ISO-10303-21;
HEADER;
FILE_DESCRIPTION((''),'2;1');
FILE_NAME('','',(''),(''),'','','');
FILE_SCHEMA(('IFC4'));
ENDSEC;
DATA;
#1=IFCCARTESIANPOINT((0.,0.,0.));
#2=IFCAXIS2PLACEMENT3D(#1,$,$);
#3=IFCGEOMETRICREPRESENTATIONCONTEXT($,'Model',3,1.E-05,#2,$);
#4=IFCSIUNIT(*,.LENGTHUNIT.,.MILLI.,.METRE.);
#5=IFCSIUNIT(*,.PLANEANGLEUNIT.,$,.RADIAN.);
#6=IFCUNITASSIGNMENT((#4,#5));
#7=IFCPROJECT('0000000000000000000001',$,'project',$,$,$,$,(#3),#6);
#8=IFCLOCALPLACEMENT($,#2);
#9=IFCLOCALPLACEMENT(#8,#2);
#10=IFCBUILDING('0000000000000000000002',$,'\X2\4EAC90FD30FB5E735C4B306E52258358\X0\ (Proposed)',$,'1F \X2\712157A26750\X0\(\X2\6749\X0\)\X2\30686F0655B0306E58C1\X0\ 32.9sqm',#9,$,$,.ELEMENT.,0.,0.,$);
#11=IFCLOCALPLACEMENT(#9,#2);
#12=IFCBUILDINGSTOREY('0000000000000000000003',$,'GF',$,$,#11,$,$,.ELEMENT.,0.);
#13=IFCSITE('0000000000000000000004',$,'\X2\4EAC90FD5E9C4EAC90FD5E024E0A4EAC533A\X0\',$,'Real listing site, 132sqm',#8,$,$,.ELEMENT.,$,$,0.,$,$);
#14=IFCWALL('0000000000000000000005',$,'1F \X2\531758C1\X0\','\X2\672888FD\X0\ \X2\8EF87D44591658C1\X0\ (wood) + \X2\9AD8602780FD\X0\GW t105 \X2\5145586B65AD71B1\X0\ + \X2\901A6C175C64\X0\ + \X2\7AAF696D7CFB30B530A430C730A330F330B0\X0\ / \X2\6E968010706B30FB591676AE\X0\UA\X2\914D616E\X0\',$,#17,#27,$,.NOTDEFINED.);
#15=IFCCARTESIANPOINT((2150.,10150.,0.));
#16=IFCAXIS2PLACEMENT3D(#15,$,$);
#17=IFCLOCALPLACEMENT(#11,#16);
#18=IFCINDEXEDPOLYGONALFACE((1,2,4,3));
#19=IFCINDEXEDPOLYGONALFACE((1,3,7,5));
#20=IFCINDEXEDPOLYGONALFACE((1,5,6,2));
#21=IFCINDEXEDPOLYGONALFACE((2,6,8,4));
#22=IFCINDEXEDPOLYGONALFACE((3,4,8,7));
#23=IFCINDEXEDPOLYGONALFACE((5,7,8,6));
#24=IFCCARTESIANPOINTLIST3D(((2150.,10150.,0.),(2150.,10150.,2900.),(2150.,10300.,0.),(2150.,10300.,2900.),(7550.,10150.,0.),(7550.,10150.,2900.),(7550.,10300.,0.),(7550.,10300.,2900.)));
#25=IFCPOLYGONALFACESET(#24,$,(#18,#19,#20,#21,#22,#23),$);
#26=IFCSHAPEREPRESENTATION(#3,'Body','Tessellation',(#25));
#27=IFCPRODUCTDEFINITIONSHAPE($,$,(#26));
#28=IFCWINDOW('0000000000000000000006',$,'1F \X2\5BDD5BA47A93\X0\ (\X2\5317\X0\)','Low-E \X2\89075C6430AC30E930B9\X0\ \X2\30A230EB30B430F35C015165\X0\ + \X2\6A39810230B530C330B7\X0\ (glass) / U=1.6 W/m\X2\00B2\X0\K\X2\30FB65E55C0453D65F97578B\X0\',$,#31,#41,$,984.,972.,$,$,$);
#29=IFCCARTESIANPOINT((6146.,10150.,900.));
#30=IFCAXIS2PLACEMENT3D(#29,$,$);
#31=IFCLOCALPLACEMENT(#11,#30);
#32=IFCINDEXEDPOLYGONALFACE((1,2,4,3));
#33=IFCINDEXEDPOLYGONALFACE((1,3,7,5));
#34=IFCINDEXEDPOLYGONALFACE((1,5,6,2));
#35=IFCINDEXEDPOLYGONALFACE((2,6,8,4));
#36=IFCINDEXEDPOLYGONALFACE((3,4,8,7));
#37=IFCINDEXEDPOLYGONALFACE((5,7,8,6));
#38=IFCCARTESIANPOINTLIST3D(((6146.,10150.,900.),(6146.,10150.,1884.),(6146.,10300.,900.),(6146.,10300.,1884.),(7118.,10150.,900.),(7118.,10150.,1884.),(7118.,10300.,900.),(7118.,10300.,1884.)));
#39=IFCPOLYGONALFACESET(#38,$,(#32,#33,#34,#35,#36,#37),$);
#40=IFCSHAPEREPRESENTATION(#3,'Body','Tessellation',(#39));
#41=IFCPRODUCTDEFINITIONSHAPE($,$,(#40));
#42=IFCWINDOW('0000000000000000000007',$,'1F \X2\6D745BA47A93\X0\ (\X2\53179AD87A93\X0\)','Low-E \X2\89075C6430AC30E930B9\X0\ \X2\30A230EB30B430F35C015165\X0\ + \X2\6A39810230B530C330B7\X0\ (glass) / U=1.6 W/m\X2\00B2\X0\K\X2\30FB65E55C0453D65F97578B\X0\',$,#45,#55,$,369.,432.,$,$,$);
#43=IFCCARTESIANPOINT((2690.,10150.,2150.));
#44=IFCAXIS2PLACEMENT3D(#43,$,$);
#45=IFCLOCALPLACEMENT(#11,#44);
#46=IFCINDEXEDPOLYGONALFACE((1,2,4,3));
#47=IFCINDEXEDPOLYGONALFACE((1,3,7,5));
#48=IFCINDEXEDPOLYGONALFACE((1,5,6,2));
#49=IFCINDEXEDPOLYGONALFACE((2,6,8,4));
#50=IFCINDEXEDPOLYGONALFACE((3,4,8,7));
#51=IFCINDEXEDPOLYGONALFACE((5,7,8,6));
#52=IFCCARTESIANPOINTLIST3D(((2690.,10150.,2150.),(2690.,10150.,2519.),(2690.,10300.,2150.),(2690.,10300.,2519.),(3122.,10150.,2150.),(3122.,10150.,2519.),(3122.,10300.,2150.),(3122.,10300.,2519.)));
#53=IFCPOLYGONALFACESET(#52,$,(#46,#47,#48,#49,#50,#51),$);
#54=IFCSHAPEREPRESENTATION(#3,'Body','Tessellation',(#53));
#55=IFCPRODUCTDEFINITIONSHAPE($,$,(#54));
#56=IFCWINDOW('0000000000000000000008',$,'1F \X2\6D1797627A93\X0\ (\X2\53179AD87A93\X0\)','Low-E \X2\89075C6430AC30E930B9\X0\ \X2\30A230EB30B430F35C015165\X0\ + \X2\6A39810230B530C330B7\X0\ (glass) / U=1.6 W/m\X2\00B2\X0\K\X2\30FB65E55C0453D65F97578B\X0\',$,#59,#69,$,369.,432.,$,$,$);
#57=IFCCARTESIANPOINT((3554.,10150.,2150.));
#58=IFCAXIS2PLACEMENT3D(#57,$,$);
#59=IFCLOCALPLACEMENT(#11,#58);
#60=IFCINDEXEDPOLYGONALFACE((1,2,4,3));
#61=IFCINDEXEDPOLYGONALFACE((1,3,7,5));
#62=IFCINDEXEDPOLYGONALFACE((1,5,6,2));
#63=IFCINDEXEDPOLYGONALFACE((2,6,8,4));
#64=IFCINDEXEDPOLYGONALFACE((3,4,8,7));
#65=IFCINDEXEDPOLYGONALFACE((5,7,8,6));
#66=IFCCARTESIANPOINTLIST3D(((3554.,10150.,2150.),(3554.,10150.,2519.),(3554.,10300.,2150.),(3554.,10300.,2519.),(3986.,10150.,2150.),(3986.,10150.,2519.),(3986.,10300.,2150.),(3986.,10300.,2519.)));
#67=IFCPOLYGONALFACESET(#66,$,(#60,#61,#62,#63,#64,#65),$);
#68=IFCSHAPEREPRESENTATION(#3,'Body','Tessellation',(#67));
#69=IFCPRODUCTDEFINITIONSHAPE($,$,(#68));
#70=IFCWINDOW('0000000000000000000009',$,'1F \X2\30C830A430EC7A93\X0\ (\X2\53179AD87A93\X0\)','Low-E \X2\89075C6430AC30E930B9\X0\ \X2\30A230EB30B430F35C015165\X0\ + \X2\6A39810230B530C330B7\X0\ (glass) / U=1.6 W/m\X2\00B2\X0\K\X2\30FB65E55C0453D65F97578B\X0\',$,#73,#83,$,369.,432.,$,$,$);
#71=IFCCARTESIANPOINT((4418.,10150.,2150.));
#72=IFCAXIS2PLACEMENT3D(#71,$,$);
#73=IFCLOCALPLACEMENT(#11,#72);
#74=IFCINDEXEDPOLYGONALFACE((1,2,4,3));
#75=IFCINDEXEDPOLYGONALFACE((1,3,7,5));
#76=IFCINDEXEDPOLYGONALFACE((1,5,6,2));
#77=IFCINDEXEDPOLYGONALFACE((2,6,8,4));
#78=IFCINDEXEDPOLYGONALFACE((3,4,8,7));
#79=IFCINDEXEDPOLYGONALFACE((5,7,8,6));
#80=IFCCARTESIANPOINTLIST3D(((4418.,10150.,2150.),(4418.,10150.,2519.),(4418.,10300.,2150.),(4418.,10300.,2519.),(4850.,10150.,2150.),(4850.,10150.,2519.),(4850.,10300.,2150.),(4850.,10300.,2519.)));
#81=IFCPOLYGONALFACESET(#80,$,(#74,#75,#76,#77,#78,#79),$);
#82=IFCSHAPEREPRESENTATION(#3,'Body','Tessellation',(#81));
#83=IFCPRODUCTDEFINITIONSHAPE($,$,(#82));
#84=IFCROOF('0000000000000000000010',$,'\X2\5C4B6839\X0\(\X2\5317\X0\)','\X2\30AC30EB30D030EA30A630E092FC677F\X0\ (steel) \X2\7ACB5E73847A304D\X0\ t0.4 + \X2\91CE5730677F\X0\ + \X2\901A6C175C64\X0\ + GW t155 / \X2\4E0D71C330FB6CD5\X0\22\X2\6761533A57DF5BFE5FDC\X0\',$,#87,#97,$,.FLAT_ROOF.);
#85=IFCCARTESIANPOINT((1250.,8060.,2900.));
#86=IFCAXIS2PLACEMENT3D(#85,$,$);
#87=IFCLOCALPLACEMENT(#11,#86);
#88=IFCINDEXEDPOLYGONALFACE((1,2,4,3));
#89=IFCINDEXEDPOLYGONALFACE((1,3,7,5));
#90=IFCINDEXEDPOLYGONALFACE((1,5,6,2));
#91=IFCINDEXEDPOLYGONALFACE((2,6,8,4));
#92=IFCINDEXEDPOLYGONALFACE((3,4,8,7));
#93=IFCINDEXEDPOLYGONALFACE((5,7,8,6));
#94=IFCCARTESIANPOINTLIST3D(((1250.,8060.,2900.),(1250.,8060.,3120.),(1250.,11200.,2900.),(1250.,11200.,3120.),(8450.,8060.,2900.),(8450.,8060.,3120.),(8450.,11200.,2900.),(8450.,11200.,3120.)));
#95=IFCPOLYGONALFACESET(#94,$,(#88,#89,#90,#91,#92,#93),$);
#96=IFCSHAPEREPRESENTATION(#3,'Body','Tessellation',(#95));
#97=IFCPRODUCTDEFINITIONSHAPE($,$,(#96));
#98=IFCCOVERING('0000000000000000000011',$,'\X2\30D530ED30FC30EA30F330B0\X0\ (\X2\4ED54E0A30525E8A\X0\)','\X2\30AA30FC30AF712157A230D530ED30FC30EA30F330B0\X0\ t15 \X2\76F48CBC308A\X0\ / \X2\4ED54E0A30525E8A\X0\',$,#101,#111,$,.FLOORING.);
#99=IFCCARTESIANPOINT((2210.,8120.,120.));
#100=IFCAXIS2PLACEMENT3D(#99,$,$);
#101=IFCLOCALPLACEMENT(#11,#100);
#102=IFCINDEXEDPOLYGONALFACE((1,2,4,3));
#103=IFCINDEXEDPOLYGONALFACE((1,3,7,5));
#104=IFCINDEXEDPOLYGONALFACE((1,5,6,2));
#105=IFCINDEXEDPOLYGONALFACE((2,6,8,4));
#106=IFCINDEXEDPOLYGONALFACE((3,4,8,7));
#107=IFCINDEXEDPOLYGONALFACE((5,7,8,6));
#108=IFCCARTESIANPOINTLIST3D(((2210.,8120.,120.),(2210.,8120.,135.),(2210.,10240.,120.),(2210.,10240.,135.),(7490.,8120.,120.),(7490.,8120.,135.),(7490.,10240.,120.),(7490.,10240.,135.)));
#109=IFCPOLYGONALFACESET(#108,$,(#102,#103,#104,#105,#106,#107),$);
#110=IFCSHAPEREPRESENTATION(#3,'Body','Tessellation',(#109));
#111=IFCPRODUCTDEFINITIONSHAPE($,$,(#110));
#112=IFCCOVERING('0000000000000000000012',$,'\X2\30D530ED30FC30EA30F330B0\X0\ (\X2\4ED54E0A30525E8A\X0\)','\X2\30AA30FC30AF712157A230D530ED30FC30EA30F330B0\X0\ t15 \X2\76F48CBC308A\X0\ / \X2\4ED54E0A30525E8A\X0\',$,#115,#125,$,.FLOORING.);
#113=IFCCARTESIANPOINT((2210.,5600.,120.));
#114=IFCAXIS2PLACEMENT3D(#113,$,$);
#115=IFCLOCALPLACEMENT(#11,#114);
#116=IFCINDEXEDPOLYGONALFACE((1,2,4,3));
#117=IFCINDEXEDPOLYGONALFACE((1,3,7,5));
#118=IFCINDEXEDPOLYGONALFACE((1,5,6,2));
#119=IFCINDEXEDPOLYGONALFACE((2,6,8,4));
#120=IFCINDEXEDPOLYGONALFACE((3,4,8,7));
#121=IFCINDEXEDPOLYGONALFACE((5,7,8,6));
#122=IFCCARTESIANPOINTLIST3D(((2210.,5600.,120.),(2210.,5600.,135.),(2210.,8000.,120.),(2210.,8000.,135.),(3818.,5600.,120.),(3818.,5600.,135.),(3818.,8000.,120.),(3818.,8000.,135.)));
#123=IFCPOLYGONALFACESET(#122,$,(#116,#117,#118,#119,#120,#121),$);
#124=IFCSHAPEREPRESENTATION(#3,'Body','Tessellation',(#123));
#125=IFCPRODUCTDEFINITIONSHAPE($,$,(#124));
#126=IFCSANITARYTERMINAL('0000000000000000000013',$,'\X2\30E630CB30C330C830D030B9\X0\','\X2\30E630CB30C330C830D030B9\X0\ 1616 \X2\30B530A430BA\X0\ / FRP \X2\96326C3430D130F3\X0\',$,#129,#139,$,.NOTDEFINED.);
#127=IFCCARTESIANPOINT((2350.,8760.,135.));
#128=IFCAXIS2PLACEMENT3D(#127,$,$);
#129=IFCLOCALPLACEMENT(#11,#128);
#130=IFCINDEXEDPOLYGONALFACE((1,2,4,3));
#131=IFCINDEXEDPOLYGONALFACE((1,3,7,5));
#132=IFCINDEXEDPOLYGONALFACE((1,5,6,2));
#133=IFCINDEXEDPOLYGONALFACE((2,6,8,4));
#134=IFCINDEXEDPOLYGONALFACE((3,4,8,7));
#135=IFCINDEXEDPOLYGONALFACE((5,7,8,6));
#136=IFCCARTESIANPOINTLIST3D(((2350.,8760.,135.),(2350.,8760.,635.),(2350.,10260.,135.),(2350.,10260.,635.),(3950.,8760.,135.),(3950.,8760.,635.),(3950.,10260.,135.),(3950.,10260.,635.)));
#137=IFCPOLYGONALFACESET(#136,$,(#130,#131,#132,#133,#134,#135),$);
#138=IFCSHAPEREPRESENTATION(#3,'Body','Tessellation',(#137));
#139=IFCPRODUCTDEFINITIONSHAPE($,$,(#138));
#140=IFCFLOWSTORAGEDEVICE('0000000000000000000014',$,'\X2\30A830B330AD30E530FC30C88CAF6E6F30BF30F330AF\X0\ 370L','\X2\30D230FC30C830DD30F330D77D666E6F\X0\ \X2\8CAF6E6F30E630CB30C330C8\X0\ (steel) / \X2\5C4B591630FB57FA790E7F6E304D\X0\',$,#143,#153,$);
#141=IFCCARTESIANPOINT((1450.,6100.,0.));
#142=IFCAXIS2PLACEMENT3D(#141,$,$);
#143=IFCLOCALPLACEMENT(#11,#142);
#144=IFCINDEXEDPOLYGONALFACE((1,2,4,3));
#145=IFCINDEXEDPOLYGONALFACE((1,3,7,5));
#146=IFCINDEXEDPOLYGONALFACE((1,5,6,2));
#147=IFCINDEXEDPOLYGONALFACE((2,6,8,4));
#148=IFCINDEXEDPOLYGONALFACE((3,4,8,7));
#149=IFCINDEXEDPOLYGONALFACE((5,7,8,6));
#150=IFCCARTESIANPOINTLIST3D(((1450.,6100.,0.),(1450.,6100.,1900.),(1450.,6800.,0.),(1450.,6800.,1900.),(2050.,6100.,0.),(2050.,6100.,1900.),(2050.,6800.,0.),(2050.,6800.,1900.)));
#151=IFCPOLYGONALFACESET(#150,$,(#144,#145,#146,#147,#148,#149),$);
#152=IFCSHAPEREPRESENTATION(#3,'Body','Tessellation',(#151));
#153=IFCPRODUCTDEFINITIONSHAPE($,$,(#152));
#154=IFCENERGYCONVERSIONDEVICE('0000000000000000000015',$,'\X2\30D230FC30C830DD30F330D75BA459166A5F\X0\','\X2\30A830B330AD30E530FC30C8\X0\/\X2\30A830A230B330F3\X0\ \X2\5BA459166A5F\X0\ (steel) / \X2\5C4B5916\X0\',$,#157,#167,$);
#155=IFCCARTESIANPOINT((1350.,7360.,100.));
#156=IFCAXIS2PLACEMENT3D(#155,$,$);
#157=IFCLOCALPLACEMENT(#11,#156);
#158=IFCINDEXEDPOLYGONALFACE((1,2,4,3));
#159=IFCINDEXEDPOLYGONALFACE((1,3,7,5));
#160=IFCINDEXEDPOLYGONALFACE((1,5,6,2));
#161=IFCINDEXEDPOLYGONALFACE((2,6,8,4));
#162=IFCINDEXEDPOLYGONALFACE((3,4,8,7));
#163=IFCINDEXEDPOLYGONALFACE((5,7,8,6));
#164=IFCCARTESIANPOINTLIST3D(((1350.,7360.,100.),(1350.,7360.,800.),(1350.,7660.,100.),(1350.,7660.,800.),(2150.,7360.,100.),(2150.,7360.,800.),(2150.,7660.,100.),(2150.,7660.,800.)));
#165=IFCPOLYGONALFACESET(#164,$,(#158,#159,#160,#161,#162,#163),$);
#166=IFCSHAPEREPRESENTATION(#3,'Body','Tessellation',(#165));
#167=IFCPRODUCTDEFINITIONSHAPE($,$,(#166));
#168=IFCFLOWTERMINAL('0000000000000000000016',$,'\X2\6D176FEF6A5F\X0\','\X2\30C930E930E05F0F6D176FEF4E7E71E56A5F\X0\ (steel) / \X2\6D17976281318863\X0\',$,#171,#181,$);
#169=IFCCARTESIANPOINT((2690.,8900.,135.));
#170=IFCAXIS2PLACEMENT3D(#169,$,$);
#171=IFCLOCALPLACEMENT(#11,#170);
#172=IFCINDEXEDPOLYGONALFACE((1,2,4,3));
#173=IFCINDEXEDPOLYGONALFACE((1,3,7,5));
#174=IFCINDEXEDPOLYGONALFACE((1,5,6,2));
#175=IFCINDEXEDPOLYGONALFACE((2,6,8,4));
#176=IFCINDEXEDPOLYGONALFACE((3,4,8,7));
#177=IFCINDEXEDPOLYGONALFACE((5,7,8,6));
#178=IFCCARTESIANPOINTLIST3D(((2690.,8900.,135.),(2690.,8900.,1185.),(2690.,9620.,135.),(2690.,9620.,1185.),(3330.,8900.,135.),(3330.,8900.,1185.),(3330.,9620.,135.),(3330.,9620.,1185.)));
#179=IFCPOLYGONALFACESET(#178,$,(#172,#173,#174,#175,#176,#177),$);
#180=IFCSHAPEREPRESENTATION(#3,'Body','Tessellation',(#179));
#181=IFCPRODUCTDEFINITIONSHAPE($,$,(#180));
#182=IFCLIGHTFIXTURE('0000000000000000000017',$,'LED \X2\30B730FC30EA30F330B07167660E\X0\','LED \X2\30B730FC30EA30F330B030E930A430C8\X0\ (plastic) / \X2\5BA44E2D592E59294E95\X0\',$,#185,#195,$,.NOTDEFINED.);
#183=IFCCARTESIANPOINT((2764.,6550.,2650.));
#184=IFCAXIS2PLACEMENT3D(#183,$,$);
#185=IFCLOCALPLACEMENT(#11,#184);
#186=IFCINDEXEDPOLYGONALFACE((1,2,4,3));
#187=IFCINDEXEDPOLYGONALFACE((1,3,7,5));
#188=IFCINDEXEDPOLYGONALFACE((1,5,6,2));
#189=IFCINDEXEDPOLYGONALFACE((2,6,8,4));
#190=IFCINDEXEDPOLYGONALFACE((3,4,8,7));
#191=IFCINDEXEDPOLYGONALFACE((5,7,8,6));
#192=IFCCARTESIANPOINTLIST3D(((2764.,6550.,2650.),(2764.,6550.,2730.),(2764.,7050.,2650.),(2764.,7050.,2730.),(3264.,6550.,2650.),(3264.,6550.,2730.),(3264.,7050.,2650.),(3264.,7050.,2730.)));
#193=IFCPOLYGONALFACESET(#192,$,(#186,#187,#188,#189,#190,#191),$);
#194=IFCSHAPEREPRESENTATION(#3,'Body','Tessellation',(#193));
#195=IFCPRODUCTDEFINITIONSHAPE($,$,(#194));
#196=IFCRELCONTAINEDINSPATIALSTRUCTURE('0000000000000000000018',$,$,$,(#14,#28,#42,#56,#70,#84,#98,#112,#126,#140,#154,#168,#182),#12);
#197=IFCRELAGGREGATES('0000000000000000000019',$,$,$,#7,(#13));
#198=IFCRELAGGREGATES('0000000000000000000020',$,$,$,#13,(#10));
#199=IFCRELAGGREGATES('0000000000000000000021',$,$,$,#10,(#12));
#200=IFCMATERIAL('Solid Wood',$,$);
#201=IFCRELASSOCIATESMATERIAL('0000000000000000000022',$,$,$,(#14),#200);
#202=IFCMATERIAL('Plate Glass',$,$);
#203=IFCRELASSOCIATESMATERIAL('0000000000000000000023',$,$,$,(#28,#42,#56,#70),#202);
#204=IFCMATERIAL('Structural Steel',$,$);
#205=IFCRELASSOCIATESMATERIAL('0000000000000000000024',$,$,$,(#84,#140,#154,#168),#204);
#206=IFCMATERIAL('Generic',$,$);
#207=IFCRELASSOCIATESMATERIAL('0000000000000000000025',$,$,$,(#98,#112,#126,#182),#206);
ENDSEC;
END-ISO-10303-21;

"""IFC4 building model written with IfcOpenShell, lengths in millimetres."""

from ifc_helpers import new_model, si_unit, frame, frame_2d, origin, place, context, project, spatial, rectangle, extrude, material, element, fill, save


model = new_model("IFC4")

# Units and contexts
model_context = context("Model", 3, precision=1e-05, world=origin())
ifc_project = project(units=[si_unit("LENGTHUNIT", "METRE", prefix="MILLI"), si_unit("PLANEANGLEUNIT", "RADIAN")], contexts=[model_context])

# Site, building, storey
site_placement = place(None, origin())
site = spatial("IfcSite", under=ifc_project, at=site_placement, Name="京都府京都市上京区", ObjectType="Real listing site, 132sqm", CompositionType="ELEMENT", RefElevation=0.0)
building_placement = place(site_placement, origin())
building = spatial("IfcBuilding", under=site, at=building_placement, Name="京都・平屋の別荘 (Proposed)", ObjectType="1F 無垢材(杉)と漆喰の壁 32.9sqm", CompositionType="ELEMENT", ElevationOfRefHeight=0.0, ElevationOfTerrain=0.0)
storey_placement = place(building_placement, origin())
storey = spatial("IfcBuildingStorey", under=building, at=storey_placement, Name="GF", CompositionType="ELEMENT", Elevation=0.0)

# Shared definitions
ifc_material_1 = material(Name="Solid Wood")

# Wall, openings, windows
wall_1_placement = place(storey_placement, frame((2150.0, 10150.0, 0.0)))
wall_1 = element("IfcWall", 1, at=wall_1_placement, inside=storey, material=ifc_material_1, Name="1F 北壁", Description="木製 軸組外壁 (wood) + 高性能GW t105 充填断熱 + 通気層 + 窯業系サイディング / 準耐火・外皮UA配慮", PredefinedType="NOTDEFINED", context=model_context, shape_type="SweptSolid", body=[
    extrude(rectangle(XDim=5400.0, YDim=150.0, at=frame_2d((2700.0, 75.0))), frame((2150.0, 10150.0, 0.0)), (0.0, 0.0, 1.0), 2900.0),
])
opening_1_placement = place(storey_placement, frame((6146.0, 10150.0, 900.0)))
opening_1 = element("IfcOpeningElement", 2, at=opening_1_placement, cuts=wall_1, PredefinedType="NOTDEFINED", context=model_context, shape_type="SweptSolid", body=[
    extrude(rectangle(XDim=972.0, YDim=150.0, at=frame_2d((486.0, 75.0))), frame((6146.0, 10150.0, 900.0)), (0.0, 0.0, 1.0), 984.0),
])
opening_2_placement = place(storey_placement, frame((2690.0, 10150.0, 2150.0)))
opening_2 = element("IfcOpeningElement", 3, at=opening_2_placement, cuts=wall_1, PredefinedType="NOTDEFINED", context=model_context, shape_type="SweptSolid", body=[
    extrude(rectangle(XDim=432.0, YDim=150.0, at=frame_2d((216.0, 75.0))), frame((2690.0, 10150.0, 2150.0)), (0.0, 0.0, 1.0), 369.0),
])
opening_3_placement = place(storey_placement, frame((3554.0, 10150.0, 2150.0)))
opening_3 = element("IfcOpeningElement", 4, at=opening_3_placement, cuts=wall_1, PredefinedType="NOTDEFINED", context=model_context, shape_type="SweptSolid", body=[
    extrude(rectangle(XDim=432.0, YDim=150.0, at=frame_2d((216.0, 75.0))), frame((3554.0, 10150.0, 2150.0)), (0.0, 0.0, 1.0), 369.0),
])
opening_4_placement = place(storey_placement, frame((4418.0, 10150.0, 2150.0)))
opening_4 = element("IfcOpeningElement", 5, at=opening_4_placement, cuts=wall_1, PredefinedType="NOTDEFINED", context=model_context, shape_type="SweptSolid", body=[
    extrude(rectangle(XDim=432.0, YDim=150.0, at=frame_2d((216.0, 75.0))), frame((4418.0, 10150.0, 2150.0)), (0.0, 0.0, 1.0), 369.0),
])
ifc_material_2 = material(Name="Plate Glass")
window_1_placement = place(storey_placement, frame((6146.0, 10150.0, 900.0)))
window_1 = element("IfcWindow", 6, at=window_1_placement, inside=storey, material=ifc_material_2, Name="1F 寝室窓 (北)", Description="Low-E 複層ガラス アルゴン封入 + 樹脂サッシ (glass) / U=1.6 W/m²K・日射取得型", OverallHeight=984.0, OverallWidth=972.0, context=model_context, shape_type="SweptSolid", body=[
    extrude(rectangle(XDim=972.0, YDim=150.0, at=frame_2d((486.0, 75.0))), frame((6146.0, 10150.0, 900.0)), (0.0, 0.0, 1.0), 984.0),
])
fill(opening_1, window_1)
window_2_placement = place(storey_placement, frame((2690.0, 10150.0, 2150.0)))
window_2 = element("IfcWindow", 7, at=window_2_placement, inside=storey, material=ifc_material_2, Name="1F 浴室窓 (北高窓)", Description="Low-E 複層ガラス アルゴン封入 + 樹脂サッシ (glass) / U=1.6 W/m²K・日射取得型", OverallHeight=369.0, OverallWidth=432.0, context=model_context, shape_type="SweptSolid", body=[
    extrude(rectangle(XDim=432.0, YDim=150.0, at=frame_2d((216.0, 75.0))), frame((2690.0, 10150.0, 2150.0)), (0.0, 0.0, 1.0), 369.0),
])
fill(opening_2, window_2)
window_3_placement = place(storey_placement, frame((3554.0, 10150.0, 2150.0)))
window_3 = element("IfcWindow", 8, at=window_3_placement, inside=storey, material=ifc_material_2, Name="1F 洗面窓 (北高窓)", Description="Low-E 複層ガラス アルゴン封入 + 樹脂サッシ (glass) / U=1.6 W/m²K・日射取得型", OverallHeight=369.0, OverallWidth=432.0, context=model_context, shape_type="SweptSolid", body=[
    extrude(rectangle(XDim=432.0, YDim=150.0, at=frame_2d((216.0, 75.0))), frame((3554.0, 10150.0, 2150.0)), (0.0, 0.0, 1.0), 369.0),
])
fill(opening_3, window_3)
window_4_placement = place(storey_placement, frame((4418.0, 10150.0, 2150.0)))
window_4 = element("IfcWindow", 9, at=window_4_placement, inside=storey, material=ifc_material_2, Name="1F トイレ窓 (北高窓)", Description="Low-E 複層ガラス アルゴン封入 + 樹脂サッシ (glass) / U=1.6 W/m²K・日射取得型", OverallHeight=369.0, OverallWidth=432.0, context=model_context, shape_type="SweptSolid", body=[
    extrude(rectangle(XDim=432.0, YDim=150.0, at=frame_2d((216.0, 75.0))), frame((4418.0, 10150.0, 2150.0)), (0.0, 0.0, 1.0), 369.0),
])
fill(opening_4, window_4)

# Roof
ifc_material_3 = material(Name="Structural Steel")
roof_placement = place(storey_placement, frame((1250.0, 8060.0, 2900.0)))
element("IfcRoof", 10, at=roof_placement, inside=storey, material=ifc_material_3, Name="屋根(北)", Description="ガルバリウム鋼板 (steel) 立平葺き t0.4 + 野地板 + 通気層 + GW t155 / 不燃・法22条区域対応", PredefinedType="FLAT_ROOF", context=model_context, shape_type="SweptSolid", body=[
    extrude(rectangle(XDim=7200.0, YDim=3140.0, at=frame_2d((3600.0, 1570.0))), frame((1250.0, 8060.0, 2900.0)), (0.0, 0.0, 1.0), 220.0),
])

# Coverings
ifc_material_4 = material(Name="Generic")
covering_1_placement = place(storey_placement, frame((2210.0, 8120.0, 120.0)))
element("IfcCovering", 11, at=covering_1_placement, inside=storey, material=ifc_material_4, Name="フローリング (仕上げ床)", Description="オーク無垢フローリング t15 直貼り / 仕上げ床", PredefinedType="FLOORING", context=model_context, shape_type="SweptSolid", body=[
    extrude(rectangle(XDim=5280.0, YDim=2120.0, at=frame_2d((2640.0, 1060.0))), frame((2210.0, 8120.0, 120.0)), (0.0, 0.0, 1.0), 15.0),
])
covering_2_placement = place(storey_placement, frame((2210.0, 5600.0, 120.0)))
element("IfcCovering", 12, at=covering_2_placement, inside=storey, material=ifc_material_4, Name="フローリング (仕上げ床)", Description="オーク無垢フローリング t15 直貼り / 仕上げ床", PredefinedType="FLOORING", context=model_context, shape_type="SweptSolid", body=[
    extrude(rectangle(XDim=1608.0, YDim=2400.0, at=frame_2d((804.0, 1200.0))), frame((2210.0, 5600.0, 120.0)), (0.0, 0.0, 1.0), 15.0),
])

# Sanitary terminal
sanitary_terminal_placement = place(storey_placement, frame((2350.0, 8760.0, 135.0)))
element("IfcSanitaryTerminal", 13, at=sanitary_terminal_placement, inside=storey, material=ifc_material_4, Name="ユニットバス", Description="ユニットバス 1616 サイズ / FRP 防水パン", PredefinedType="NOTDEFINED", context=model_context, shape_type="SweptSolid", body=[
    extrude(rectangle(XDim=1600.0, YDim=1500.0, at=frame_2d((800.0, 750.0))), frame((2350.0, 8760.0, 135.0)), (0.0, 0.0, 1.0), 500.0),
])

# Flow storage device
flow_storage_device_placement = place(storey_placement, frame((1450.0, 6100.0, 0.0)))
element("IfcFlowStorageDevice", 14, at=flow_storage_device_placement, inside=storey, material=ifc_material_3, Name="エコキュート貯湯タンク 370L", Description="ヒートポンプ給湯 貯湯ユニット (steel) / 屋外・基礎置き", context=model_context, shape_type="SweptSolid", body=[
    extrude(rectangle(XDim=600.0, YDim=700.0, at=frame_2d((300.0, 350.0))), frame((1450.0, 6100.0, 0.0)), (0.0, 0.0, 1.0), 1900.0),
])

# Energy conversion device
energy_conversion_device_placement = place(storey_placement, frame((1350.0, 7360.0, 100.0)))
element("IfcEnergyConversionDevice", 15, at=energy_conversion_device_placement, inside=storey, material=ifc_material_3, Name="ヒートポンプ室外機", Description="エコキュート/エアコン 室外機 (steel) / 屋外", context=model_context, shape_type="SweptSolid", body=[
    extrude(rectangle(XDim=800.0, YDim=300.0, at=frame_2d((400.0, 150.0))), frame((1350.0, 7360.0, 100.0)), (0.0, 0.0, 1.0), 700.0),
])

# Flow terminal
flow_terminal_placement = place(storey_placement, frame((2690.0, 8900.0, 135.0)))
element("IfcFlowTerminal", 16, at=flow_terminal_placement, inside=storey, material=ifc_material_3, Name="洗濯機", Description="ドラム式洗濯乾燥機 (steel) / 洗面脱衣", context=model_context, shape_type="SweptSolid", body=[
    extrude(rectangle(XDim=640.0, YDim=720.0, at=frame_2d((320.0, 360.0))), frame((2690.0, 8900.0, 135.0)), (0.0, 0.0, 1.0), 1050.0),
])

# Light fixture
light_fixture_placement = place(storey_placement, frame((2764.0, 6550.0, 2650.0)))
element("IfcLightFixture", 17, at=light_fixture_placement, inside=storey, material=ifc_material_4, Name="LED シーリング照明", Description="LED シーリングライト (plastic) / 室中央天井", PredefinedType="NOTDEFINED", context=model_context, shape_type="SweptSolid", body=[
    extrude(rectangle(XDim=500.0, YDim=500.0, at=frame_2d((250.0, 250.0))), frame((2764.0, 6550.0, 2650.0)), (0.0, 0.0, 1.0), 80.0),
])

save(model, "model.ifc")
